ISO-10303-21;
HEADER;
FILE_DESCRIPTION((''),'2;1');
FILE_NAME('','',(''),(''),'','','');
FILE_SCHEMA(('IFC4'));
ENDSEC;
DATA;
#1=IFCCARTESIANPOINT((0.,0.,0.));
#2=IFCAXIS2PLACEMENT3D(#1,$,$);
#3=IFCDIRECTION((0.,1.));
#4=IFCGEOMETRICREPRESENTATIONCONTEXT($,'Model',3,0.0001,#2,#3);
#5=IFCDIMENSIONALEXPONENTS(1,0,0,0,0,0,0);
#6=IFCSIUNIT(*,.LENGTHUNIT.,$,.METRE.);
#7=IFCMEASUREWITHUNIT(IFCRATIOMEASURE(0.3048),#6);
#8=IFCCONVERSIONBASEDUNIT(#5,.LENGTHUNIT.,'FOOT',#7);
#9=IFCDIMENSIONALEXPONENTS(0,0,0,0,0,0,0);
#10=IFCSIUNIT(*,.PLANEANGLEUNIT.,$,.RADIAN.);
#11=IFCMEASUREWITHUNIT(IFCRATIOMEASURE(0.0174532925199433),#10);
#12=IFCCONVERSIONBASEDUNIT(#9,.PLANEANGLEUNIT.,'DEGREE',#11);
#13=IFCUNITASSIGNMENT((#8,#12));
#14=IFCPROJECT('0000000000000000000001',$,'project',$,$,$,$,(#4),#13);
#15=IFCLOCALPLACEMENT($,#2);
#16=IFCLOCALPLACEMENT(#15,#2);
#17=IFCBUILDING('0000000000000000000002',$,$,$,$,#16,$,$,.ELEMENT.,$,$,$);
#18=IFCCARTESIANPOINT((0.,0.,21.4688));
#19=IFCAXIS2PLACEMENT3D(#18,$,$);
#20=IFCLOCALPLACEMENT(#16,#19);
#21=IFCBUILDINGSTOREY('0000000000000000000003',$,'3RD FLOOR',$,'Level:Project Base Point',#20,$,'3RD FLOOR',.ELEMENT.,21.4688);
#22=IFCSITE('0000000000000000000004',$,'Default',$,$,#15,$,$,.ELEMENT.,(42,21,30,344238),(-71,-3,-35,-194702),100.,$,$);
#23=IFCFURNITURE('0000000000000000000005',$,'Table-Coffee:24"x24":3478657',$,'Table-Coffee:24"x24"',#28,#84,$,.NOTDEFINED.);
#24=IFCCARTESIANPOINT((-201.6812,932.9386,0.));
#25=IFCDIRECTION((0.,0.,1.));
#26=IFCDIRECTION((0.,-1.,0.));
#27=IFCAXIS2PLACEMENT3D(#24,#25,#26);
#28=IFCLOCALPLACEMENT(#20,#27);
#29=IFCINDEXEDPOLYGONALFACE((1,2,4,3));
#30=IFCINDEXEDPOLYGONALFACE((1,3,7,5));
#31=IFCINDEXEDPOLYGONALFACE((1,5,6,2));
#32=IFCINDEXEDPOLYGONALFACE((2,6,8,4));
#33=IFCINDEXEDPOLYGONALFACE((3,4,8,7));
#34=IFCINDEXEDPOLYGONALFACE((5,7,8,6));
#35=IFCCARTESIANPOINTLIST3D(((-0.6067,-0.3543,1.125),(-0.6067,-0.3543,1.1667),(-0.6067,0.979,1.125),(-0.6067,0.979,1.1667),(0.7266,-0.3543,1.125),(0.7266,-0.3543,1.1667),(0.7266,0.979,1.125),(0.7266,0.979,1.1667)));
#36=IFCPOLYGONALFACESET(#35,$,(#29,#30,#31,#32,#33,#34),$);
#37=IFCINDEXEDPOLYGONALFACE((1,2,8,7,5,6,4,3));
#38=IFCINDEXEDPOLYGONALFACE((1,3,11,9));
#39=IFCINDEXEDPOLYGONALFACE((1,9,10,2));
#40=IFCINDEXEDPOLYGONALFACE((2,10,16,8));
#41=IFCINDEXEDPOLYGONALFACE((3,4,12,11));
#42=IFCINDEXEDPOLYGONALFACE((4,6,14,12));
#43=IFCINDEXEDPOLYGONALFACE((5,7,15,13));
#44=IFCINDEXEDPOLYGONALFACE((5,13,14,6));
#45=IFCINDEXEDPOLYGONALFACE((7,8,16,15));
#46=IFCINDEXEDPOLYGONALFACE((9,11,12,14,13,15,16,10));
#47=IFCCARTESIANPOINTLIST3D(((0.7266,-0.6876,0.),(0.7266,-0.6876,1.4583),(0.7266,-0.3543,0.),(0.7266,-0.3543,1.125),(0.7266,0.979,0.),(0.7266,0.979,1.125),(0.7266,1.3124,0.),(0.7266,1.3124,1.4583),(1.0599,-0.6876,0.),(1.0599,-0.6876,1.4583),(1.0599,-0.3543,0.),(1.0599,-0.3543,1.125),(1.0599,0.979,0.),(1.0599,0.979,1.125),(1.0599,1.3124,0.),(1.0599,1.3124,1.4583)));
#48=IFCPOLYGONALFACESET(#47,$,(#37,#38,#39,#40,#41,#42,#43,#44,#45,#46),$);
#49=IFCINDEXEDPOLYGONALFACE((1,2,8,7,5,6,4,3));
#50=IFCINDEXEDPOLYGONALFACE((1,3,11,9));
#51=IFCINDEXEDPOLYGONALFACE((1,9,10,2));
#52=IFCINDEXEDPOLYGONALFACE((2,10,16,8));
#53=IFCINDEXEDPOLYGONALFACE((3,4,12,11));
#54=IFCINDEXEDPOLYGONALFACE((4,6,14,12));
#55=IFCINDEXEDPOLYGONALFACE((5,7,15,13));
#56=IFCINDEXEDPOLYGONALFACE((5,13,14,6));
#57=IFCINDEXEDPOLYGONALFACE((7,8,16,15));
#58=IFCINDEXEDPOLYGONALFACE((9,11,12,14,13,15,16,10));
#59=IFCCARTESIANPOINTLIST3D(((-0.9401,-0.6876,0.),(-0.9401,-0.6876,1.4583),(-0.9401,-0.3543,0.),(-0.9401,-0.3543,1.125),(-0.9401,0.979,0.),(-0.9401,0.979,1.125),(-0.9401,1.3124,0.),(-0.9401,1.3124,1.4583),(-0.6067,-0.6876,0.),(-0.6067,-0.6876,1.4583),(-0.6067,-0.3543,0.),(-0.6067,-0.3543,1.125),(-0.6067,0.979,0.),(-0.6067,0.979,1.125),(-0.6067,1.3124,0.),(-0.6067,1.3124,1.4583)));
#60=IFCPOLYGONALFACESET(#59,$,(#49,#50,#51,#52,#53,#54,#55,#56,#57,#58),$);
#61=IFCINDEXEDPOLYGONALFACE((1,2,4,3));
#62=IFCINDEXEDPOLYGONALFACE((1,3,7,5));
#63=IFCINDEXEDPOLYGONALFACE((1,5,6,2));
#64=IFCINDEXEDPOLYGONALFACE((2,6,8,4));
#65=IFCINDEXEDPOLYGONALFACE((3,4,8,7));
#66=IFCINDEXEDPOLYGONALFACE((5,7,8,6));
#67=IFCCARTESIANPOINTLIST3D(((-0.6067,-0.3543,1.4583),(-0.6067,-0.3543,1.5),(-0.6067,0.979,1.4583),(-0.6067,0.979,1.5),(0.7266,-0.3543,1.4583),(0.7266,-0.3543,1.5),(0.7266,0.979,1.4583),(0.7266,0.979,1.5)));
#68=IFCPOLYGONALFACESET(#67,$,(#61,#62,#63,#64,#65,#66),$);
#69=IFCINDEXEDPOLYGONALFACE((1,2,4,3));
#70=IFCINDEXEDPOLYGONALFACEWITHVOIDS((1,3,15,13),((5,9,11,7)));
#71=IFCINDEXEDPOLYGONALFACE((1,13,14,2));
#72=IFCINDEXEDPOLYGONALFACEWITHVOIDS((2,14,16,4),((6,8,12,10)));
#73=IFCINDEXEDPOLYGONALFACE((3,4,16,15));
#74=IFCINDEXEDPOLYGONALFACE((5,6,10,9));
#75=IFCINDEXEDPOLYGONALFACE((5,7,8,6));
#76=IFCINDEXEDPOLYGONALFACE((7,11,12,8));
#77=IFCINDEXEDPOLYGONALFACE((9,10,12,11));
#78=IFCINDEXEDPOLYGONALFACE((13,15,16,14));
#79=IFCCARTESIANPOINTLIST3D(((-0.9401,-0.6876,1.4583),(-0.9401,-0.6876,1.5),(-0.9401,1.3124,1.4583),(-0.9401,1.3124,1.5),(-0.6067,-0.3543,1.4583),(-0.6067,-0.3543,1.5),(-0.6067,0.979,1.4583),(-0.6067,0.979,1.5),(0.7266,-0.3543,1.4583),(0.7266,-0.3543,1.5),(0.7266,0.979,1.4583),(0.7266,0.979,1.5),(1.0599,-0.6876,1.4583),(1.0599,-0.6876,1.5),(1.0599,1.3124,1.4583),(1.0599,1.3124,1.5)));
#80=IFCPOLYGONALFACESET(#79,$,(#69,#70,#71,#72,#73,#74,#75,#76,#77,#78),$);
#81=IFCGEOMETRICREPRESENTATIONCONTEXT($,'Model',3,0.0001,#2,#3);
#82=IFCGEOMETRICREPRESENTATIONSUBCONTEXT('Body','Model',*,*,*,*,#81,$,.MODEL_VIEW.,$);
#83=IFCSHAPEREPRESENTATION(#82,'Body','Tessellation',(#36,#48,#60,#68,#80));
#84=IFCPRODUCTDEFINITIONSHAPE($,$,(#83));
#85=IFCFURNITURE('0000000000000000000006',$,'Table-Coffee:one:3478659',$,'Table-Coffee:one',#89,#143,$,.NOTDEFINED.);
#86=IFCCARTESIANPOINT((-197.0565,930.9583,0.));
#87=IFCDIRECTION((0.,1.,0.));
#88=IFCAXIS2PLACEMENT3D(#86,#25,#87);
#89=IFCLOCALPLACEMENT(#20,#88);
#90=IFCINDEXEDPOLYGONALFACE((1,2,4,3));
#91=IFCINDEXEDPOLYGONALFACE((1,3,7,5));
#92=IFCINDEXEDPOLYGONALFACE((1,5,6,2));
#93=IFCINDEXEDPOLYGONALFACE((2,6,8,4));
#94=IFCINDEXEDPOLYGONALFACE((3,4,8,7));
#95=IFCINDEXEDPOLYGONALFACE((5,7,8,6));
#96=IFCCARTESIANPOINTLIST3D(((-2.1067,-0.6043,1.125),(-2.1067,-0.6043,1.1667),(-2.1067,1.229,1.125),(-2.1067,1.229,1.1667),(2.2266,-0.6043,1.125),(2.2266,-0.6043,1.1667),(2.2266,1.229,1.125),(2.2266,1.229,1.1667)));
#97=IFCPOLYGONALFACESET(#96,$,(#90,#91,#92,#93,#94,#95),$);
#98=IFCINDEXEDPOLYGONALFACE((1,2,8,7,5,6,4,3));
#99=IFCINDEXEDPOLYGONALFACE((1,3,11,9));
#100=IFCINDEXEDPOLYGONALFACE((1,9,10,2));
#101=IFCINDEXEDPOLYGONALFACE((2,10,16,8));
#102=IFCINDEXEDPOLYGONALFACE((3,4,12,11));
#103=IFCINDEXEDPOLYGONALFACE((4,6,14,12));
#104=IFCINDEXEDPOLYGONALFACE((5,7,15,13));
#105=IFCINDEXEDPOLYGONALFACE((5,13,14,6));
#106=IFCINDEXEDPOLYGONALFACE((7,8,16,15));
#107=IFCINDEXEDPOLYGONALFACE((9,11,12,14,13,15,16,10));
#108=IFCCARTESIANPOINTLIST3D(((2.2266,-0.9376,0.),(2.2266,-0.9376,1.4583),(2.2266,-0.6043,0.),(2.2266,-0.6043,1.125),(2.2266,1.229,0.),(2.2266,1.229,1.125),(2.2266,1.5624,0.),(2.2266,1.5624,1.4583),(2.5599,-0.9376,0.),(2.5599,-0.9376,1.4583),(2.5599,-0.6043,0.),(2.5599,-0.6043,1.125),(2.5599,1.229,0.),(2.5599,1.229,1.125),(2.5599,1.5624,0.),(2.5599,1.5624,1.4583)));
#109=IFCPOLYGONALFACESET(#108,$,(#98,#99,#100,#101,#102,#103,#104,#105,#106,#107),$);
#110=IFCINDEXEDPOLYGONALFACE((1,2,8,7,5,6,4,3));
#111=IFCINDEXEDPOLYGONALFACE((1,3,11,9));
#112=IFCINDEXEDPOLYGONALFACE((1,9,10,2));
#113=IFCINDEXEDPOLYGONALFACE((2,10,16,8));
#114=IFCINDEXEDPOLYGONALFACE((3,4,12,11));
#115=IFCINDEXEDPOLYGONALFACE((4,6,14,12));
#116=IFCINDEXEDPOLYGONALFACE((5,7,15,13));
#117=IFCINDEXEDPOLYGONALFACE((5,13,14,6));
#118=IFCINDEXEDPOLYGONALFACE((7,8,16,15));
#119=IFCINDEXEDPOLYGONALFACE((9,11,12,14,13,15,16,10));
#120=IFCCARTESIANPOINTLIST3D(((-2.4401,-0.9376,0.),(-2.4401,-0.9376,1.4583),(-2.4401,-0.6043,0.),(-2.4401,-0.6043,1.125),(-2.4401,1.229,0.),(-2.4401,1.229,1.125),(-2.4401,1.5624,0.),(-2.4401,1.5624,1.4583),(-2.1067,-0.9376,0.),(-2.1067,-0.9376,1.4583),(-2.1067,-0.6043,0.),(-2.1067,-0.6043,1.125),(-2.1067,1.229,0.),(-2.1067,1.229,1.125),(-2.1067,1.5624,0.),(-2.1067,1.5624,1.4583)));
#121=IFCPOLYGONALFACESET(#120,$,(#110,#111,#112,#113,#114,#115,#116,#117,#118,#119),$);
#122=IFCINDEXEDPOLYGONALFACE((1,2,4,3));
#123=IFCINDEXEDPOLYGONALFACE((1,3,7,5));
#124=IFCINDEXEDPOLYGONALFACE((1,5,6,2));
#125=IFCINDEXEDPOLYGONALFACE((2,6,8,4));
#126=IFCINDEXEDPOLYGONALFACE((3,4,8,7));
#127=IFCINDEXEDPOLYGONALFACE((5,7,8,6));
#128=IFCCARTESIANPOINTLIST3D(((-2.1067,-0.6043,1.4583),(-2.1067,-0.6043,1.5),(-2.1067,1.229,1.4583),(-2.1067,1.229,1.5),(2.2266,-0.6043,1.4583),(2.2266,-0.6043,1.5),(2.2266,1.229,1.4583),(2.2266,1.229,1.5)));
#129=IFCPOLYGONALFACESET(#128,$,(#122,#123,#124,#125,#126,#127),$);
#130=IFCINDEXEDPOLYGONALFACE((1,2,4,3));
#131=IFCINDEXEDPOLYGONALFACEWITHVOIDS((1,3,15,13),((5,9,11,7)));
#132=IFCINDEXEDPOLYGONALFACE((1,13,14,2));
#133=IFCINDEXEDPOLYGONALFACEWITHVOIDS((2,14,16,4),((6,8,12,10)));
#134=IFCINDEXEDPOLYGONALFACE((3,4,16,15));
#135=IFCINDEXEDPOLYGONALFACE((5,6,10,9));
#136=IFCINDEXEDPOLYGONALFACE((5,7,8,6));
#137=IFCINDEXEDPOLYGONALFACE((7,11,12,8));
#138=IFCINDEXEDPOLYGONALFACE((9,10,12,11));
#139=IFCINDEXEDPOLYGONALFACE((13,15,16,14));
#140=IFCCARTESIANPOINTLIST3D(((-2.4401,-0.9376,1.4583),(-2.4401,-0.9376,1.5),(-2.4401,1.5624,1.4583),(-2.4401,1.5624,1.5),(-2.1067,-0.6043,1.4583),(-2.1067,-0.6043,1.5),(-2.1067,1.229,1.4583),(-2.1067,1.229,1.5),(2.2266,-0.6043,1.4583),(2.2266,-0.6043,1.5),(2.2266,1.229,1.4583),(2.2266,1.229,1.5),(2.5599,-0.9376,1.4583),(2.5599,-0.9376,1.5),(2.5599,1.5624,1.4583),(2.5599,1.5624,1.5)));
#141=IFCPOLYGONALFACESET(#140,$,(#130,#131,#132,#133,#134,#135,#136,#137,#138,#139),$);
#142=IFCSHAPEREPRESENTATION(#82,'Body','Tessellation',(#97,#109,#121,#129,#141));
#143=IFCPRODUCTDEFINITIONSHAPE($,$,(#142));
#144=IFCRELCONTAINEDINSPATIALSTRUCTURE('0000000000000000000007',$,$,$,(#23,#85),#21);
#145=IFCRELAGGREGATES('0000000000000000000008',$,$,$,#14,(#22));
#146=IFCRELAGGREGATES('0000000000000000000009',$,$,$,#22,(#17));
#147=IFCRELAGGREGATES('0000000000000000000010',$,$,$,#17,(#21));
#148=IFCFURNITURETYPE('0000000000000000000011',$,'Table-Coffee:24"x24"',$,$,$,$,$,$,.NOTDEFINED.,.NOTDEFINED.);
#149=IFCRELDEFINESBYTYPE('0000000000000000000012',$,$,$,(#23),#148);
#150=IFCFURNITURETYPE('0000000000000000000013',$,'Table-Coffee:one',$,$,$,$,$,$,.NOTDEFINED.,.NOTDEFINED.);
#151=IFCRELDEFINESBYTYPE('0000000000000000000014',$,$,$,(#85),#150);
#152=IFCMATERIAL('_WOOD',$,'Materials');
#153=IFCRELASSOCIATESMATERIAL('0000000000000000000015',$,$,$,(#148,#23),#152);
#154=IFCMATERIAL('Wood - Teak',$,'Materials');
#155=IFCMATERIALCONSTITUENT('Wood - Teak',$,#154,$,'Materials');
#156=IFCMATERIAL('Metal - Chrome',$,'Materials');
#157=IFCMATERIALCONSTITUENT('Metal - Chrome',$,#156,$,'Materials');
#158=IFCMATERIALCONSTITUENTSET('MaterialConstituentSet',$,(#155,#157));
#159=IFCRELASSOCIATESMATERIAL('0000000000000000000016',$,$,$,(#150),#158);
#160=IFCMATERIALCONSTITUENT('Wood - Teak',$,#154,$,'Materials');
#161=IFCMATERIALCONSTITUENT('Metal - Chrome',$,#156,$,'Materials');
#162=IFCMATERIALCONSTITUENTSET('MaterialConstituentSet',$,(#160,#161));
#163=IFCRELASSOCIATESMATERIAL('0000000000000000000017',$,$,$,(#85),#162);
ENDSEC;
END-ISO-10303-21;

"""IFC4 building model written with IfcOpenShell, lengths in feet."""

from ifc_helpers import new_model, entity, si_unit, converted_unit, direction, frame, origin, origin_2d_with_axis, place, context, subcontext, project, spatial, polyline, rectangle, outline, extrude, source, transform, mapped, material, constituent, constituent_set, type_object, type_shapes, element, save


model = new_model("IFC4")

# Units and contexts
model_context_1 = context("Model", 3, precision=0.0001, world=origin(), true_north=direction((0.0, 1.0)))
model_context_2 = context("Model", 3, precision=0.0001, world=origin(), true_north=direction((0.0, 1.0)))
body_context = subcontext(model_context_2, "Body", "Model", "MODEL_VIEW")
ifc_project = project(units=[converted_unit("LENGTHUNIT", "FOOT", entity("IfcRatioMeasure", 0.3048), si_unit("LENGTHUNIT", "METRE"), dimensions=[1, 0, 0, 0, 0, 0, 0]), converted_unit("PLANEANGLEUNIT", "DEGREE", entity("IfcRatioMeasure", 0.0174532925199433), si_unit("PLANEANGLEUNIT", "RADIAN"), dimensions=[0, 0, 0, 0, 0, 0, 0])], contexts=[model_context_1])

# Site, building, storey
site_placement = place(None, origin())
site = spatial("IfcSite", under=ifc_project, at=site_placement, Name="Default", CompositionType="ELEMENT", RefLatitude=(42, 21, 30, 344238), RefLongitude=(-71, -3, -35, -194702), RefElevation=100.0)
building_placement = place(site_placement, origin())
building = spatial("IfcBuilding", under=site, at=building_placement, CompositionType="ELEMENT")
storey_placement = place(building_placement, frame((0.0, 0.0, 21.4688)))
storey = spatial("IfcBuildingStorey", under=building, at=storey_placement, Name="3RD FLOOR", ObjectType="Level:Project Base Point", LongName="3RD FLOOR", CompositionType="ELEMENT", Elevation=21.4688)

# Furniture
ifc_material_1 = material(Name="_WOOD", Category="Materials")
furniture_type_1 = type_object("IfcFurnitureType", Name="Table-Coffee:24\"x24\"", AssemblyPlace="NOTDEFINED", PredefinedType="NOTDEFINED", material=ifc_material_1)
shared_shape_1 = source(origin(), body_context, "Body", "SweptSolid", [
    extrude(rectangle(XDim=1.3333, YDim=1.3333, at=origin_2d_with_axis()), frame((0.0599, 0.3124, 1.125), z_axis=(0.0, 0.0, 1.0), x_axis=(-1.0, 0.0, 0.0)), (0.0, 0.0, 1.0), 0.0417),
    extrude(outline(polyline([(-0.6458, -1.0), (0.8125, -1.0), (0.8125, 1.0), (-0.6458, 1.0), (-0.6458, 0.6667), (0.4792, 0.6667), (0.4792, -0.6667), (-0.6458, -0.6667), (-0.6458, -1.0)])), frame((0.7266, 0.3124, 0.6458), z_axis=(1.0, 0.0, 0.0), x_axis=(0.0, 0.0, 1.0)), (0.0, 0.0, 1.0), 0.3333),
    extrude(outline(polyline([(-1.0, -0.8125), (1.0, -0.8125), (1.0, 0.6458), (0.6667, 0.6458), (0.6667, -0.4792), (-0.6667, -0.4792), (-0.6667, 0.6458), (-1.0, 0.6458), (-1.0, -0.8125)])), frame((-0.9401, 0.3124, 0.6458), z_axis=(1.0, 0.0, 0.0), x_axis=(0.0, -1.0, 0.0)), (0.0, 0.0, 1.0), 0.3333),
    extrude(rectangle(XDim=1.3333, YDim=1.3333, at=origin_2d_with_axis()), frame((0.0599, 0.3124, 1.4583), z_axis=(0.0, 0.0, 1.0), x_axis=(-1.0, 0.0, 0.0)), (0.0, 0.0, 1.0), 0.0417),
    extrude(outline(polyline([(-1.0, -1.0), (1.0, -1.0), (1.0, 1.0), (-1.0, 1.0), (-1.0, -1.0)]), holes=[polyline([(-0.6667, -0.6667), (-0.6667, 0.6667), (0.6667, 0.6667), (0.6667, -0.6667), (-0.6667, -0.6667)])]), frame((0.0599, 0.3124, 1.4583), z_axis=(0.0, 0.0, 1.0), x_axis=(-1.0, 0.0, 0.0)), (0.0, 0.0, 1.0), 0.0417),
])
type_shapes(furniture_type_1, [shared_shape_1])
furniture_1_placement = place(storey_placement, frame((-201.6812, 932.9386, 0.0), z_axis=(0.0, 0.0, 1.0), x_axis=(0.0, -1.0, 0.0)))
element("IfcFurniture", 1, at=furniture_1_placement, inside=storey, type_object=furniture_type_1, material=ifc_material_1, Name="Table-Coffee:24\"x24\":3478657", ObjectType="Table-Coffee:24\"x24\"", PredefinedType="NOTDEFINED", context=body_context, shape_type="MappedRepresentation", body=[
    mapped(shared_shape_1, transform((0.0, 0.0, 0.0), scale=1.0)),
])
ifc_material_2 = material(Name="Wood - Teak", Category="Materials")
ifc_constituent_1 = constituent(ifc_material_2, Name="Wood - Teak", Category="Materials")
ifc_material_3 = material(Name="Metal - Chrome", Category="Materials")
ifc_constituent_2 = constituent(ifc_material_3, Name="Metal - Chrome", Category="Materials")
ifc_constituent_set_1 = constituent_set(constituents=[ifc_constituent_1, ifc_constituent_2], Name="MaterialConstituentSet")
ifc_constituent_3 = constituent(ifc_material_2, Name="Wood - Teak", Category="Materials")
ifc_constituent_4 = constituent(ifc_material_3, Name="Metal - Chrome", Category="Materials")
ifc_constituent_set_2 = constituent_set(constituents=[ifc_constituent_3, ifc_constituent_4], Name="MaterialConstituentSet")
furniture_type_2 = type_object("IfcFurnitureType", Name="Table-Coffee:one", AssemblyPlace="NOTDEFINED", PredefinedType="NOTDEFINED", material=ifc_constituent_set_2)
shared_shape_2 = source(origin(), body_context, "Body", "SweptSolid", [
    extrude(rectangle(XDim=4.3333, YDim=1.8333, at=origin_2d_with_axis()), frame((0.0599, 0.3124, 1.125), z_axis=(0.0, 0.0, 1.0), x_axis=(-1.0, 0.0, 0.0)), (0.0, 0.0, 1.0), 0.0417),
    extrude(outline(polyline([(-0.6458, -1.25), (0.8125, -1.25), (0.8125, 1.25), (-0.6458, 1.25), (-0.6458, 0.9167), (0.4792, 0.9167), (0.4792, -0.9167), (-0.6458, -0.9167), (-0.6458, -1.25)])), frame((2.2266, 0.3124, 0.6458), z_axis=(1.0, 0.0, 0.0), x_axis=(0.0, 0.0, 1.0)), (0.0, 0.0, 1.0), 0.3333),
    extrude(outline(polyline([(-1.25, -0.8125), (1.25, -0.8125), (1.25, 0.6458), (0.9167, 0.6458), (0.9167, -0.4792), (-0.9167, -0.4792), (-0.9167, 0.6458), (-1.25, 0.6458), (-1.25, -0.8125)])), frame((-2.4401, 0.3124, 0.6458), z_axis=(1.0, 0.0, 0.0), x_axis=(0.0, -1.0, 0.0)), (0.0, 0.0, 1.0), 0.3333),
    extrude(rectangle(XDim=4.3333, YDim=1.8333, at=origin_2d_with_axis()), frame((0.0599, 0.3124, 1.4583), z_axis=(0.0, 0.0, 1.0), x_axis=(-1.0, 0.0, 0.0)), (0.0, 0.0, 1.0), 0.0417),
    extrude(outline(polyline([(-2.5, -1.25), (2.5, -1.25), (2.5, 1.25), (-2.5, 1.25), (-2.5, -1.25)]), holes=[polyline([(-2.1667, -0.9167), (-2.1667, 0.9167), (2.1667, 0.9167), (2.1667, -0.9167), (-2.1667, -0.9167)])]), frame((0.0599, 0.3124, 1.4583), z_axis=(0.0, 0.0, 1.0), x_axis=(-1.0, 0.0, 0.0)), (0.0, 0.0, 1.0), 0.0417),
])
type_shapes(furniture_type_2, [shared_shape_2])
furniture_2_placement = place(storey_placement, frame((-197.0565, 930.9583, 0.0), z_axis=(0.0, 0.0, 1.0), x_axis=(0.0, 1.0, 0.0)))
element("IfcFurniture", 2, at=furniture_2_placement, inside=storey, type_object=furniture_type_2, material=ifc_constituent_set_1, Name="Table-Coffee:one:3478659", ObjectType="Table-Coffee:one", PredefinedType="NOTDEFINED", context=body_context, shape_type="MappedRepresentation", body=[
    mapped(shared_shape_2, transform((0.0, 0.0, 0.0), scale=1.0)),
])

save(model, "model.ifc")
